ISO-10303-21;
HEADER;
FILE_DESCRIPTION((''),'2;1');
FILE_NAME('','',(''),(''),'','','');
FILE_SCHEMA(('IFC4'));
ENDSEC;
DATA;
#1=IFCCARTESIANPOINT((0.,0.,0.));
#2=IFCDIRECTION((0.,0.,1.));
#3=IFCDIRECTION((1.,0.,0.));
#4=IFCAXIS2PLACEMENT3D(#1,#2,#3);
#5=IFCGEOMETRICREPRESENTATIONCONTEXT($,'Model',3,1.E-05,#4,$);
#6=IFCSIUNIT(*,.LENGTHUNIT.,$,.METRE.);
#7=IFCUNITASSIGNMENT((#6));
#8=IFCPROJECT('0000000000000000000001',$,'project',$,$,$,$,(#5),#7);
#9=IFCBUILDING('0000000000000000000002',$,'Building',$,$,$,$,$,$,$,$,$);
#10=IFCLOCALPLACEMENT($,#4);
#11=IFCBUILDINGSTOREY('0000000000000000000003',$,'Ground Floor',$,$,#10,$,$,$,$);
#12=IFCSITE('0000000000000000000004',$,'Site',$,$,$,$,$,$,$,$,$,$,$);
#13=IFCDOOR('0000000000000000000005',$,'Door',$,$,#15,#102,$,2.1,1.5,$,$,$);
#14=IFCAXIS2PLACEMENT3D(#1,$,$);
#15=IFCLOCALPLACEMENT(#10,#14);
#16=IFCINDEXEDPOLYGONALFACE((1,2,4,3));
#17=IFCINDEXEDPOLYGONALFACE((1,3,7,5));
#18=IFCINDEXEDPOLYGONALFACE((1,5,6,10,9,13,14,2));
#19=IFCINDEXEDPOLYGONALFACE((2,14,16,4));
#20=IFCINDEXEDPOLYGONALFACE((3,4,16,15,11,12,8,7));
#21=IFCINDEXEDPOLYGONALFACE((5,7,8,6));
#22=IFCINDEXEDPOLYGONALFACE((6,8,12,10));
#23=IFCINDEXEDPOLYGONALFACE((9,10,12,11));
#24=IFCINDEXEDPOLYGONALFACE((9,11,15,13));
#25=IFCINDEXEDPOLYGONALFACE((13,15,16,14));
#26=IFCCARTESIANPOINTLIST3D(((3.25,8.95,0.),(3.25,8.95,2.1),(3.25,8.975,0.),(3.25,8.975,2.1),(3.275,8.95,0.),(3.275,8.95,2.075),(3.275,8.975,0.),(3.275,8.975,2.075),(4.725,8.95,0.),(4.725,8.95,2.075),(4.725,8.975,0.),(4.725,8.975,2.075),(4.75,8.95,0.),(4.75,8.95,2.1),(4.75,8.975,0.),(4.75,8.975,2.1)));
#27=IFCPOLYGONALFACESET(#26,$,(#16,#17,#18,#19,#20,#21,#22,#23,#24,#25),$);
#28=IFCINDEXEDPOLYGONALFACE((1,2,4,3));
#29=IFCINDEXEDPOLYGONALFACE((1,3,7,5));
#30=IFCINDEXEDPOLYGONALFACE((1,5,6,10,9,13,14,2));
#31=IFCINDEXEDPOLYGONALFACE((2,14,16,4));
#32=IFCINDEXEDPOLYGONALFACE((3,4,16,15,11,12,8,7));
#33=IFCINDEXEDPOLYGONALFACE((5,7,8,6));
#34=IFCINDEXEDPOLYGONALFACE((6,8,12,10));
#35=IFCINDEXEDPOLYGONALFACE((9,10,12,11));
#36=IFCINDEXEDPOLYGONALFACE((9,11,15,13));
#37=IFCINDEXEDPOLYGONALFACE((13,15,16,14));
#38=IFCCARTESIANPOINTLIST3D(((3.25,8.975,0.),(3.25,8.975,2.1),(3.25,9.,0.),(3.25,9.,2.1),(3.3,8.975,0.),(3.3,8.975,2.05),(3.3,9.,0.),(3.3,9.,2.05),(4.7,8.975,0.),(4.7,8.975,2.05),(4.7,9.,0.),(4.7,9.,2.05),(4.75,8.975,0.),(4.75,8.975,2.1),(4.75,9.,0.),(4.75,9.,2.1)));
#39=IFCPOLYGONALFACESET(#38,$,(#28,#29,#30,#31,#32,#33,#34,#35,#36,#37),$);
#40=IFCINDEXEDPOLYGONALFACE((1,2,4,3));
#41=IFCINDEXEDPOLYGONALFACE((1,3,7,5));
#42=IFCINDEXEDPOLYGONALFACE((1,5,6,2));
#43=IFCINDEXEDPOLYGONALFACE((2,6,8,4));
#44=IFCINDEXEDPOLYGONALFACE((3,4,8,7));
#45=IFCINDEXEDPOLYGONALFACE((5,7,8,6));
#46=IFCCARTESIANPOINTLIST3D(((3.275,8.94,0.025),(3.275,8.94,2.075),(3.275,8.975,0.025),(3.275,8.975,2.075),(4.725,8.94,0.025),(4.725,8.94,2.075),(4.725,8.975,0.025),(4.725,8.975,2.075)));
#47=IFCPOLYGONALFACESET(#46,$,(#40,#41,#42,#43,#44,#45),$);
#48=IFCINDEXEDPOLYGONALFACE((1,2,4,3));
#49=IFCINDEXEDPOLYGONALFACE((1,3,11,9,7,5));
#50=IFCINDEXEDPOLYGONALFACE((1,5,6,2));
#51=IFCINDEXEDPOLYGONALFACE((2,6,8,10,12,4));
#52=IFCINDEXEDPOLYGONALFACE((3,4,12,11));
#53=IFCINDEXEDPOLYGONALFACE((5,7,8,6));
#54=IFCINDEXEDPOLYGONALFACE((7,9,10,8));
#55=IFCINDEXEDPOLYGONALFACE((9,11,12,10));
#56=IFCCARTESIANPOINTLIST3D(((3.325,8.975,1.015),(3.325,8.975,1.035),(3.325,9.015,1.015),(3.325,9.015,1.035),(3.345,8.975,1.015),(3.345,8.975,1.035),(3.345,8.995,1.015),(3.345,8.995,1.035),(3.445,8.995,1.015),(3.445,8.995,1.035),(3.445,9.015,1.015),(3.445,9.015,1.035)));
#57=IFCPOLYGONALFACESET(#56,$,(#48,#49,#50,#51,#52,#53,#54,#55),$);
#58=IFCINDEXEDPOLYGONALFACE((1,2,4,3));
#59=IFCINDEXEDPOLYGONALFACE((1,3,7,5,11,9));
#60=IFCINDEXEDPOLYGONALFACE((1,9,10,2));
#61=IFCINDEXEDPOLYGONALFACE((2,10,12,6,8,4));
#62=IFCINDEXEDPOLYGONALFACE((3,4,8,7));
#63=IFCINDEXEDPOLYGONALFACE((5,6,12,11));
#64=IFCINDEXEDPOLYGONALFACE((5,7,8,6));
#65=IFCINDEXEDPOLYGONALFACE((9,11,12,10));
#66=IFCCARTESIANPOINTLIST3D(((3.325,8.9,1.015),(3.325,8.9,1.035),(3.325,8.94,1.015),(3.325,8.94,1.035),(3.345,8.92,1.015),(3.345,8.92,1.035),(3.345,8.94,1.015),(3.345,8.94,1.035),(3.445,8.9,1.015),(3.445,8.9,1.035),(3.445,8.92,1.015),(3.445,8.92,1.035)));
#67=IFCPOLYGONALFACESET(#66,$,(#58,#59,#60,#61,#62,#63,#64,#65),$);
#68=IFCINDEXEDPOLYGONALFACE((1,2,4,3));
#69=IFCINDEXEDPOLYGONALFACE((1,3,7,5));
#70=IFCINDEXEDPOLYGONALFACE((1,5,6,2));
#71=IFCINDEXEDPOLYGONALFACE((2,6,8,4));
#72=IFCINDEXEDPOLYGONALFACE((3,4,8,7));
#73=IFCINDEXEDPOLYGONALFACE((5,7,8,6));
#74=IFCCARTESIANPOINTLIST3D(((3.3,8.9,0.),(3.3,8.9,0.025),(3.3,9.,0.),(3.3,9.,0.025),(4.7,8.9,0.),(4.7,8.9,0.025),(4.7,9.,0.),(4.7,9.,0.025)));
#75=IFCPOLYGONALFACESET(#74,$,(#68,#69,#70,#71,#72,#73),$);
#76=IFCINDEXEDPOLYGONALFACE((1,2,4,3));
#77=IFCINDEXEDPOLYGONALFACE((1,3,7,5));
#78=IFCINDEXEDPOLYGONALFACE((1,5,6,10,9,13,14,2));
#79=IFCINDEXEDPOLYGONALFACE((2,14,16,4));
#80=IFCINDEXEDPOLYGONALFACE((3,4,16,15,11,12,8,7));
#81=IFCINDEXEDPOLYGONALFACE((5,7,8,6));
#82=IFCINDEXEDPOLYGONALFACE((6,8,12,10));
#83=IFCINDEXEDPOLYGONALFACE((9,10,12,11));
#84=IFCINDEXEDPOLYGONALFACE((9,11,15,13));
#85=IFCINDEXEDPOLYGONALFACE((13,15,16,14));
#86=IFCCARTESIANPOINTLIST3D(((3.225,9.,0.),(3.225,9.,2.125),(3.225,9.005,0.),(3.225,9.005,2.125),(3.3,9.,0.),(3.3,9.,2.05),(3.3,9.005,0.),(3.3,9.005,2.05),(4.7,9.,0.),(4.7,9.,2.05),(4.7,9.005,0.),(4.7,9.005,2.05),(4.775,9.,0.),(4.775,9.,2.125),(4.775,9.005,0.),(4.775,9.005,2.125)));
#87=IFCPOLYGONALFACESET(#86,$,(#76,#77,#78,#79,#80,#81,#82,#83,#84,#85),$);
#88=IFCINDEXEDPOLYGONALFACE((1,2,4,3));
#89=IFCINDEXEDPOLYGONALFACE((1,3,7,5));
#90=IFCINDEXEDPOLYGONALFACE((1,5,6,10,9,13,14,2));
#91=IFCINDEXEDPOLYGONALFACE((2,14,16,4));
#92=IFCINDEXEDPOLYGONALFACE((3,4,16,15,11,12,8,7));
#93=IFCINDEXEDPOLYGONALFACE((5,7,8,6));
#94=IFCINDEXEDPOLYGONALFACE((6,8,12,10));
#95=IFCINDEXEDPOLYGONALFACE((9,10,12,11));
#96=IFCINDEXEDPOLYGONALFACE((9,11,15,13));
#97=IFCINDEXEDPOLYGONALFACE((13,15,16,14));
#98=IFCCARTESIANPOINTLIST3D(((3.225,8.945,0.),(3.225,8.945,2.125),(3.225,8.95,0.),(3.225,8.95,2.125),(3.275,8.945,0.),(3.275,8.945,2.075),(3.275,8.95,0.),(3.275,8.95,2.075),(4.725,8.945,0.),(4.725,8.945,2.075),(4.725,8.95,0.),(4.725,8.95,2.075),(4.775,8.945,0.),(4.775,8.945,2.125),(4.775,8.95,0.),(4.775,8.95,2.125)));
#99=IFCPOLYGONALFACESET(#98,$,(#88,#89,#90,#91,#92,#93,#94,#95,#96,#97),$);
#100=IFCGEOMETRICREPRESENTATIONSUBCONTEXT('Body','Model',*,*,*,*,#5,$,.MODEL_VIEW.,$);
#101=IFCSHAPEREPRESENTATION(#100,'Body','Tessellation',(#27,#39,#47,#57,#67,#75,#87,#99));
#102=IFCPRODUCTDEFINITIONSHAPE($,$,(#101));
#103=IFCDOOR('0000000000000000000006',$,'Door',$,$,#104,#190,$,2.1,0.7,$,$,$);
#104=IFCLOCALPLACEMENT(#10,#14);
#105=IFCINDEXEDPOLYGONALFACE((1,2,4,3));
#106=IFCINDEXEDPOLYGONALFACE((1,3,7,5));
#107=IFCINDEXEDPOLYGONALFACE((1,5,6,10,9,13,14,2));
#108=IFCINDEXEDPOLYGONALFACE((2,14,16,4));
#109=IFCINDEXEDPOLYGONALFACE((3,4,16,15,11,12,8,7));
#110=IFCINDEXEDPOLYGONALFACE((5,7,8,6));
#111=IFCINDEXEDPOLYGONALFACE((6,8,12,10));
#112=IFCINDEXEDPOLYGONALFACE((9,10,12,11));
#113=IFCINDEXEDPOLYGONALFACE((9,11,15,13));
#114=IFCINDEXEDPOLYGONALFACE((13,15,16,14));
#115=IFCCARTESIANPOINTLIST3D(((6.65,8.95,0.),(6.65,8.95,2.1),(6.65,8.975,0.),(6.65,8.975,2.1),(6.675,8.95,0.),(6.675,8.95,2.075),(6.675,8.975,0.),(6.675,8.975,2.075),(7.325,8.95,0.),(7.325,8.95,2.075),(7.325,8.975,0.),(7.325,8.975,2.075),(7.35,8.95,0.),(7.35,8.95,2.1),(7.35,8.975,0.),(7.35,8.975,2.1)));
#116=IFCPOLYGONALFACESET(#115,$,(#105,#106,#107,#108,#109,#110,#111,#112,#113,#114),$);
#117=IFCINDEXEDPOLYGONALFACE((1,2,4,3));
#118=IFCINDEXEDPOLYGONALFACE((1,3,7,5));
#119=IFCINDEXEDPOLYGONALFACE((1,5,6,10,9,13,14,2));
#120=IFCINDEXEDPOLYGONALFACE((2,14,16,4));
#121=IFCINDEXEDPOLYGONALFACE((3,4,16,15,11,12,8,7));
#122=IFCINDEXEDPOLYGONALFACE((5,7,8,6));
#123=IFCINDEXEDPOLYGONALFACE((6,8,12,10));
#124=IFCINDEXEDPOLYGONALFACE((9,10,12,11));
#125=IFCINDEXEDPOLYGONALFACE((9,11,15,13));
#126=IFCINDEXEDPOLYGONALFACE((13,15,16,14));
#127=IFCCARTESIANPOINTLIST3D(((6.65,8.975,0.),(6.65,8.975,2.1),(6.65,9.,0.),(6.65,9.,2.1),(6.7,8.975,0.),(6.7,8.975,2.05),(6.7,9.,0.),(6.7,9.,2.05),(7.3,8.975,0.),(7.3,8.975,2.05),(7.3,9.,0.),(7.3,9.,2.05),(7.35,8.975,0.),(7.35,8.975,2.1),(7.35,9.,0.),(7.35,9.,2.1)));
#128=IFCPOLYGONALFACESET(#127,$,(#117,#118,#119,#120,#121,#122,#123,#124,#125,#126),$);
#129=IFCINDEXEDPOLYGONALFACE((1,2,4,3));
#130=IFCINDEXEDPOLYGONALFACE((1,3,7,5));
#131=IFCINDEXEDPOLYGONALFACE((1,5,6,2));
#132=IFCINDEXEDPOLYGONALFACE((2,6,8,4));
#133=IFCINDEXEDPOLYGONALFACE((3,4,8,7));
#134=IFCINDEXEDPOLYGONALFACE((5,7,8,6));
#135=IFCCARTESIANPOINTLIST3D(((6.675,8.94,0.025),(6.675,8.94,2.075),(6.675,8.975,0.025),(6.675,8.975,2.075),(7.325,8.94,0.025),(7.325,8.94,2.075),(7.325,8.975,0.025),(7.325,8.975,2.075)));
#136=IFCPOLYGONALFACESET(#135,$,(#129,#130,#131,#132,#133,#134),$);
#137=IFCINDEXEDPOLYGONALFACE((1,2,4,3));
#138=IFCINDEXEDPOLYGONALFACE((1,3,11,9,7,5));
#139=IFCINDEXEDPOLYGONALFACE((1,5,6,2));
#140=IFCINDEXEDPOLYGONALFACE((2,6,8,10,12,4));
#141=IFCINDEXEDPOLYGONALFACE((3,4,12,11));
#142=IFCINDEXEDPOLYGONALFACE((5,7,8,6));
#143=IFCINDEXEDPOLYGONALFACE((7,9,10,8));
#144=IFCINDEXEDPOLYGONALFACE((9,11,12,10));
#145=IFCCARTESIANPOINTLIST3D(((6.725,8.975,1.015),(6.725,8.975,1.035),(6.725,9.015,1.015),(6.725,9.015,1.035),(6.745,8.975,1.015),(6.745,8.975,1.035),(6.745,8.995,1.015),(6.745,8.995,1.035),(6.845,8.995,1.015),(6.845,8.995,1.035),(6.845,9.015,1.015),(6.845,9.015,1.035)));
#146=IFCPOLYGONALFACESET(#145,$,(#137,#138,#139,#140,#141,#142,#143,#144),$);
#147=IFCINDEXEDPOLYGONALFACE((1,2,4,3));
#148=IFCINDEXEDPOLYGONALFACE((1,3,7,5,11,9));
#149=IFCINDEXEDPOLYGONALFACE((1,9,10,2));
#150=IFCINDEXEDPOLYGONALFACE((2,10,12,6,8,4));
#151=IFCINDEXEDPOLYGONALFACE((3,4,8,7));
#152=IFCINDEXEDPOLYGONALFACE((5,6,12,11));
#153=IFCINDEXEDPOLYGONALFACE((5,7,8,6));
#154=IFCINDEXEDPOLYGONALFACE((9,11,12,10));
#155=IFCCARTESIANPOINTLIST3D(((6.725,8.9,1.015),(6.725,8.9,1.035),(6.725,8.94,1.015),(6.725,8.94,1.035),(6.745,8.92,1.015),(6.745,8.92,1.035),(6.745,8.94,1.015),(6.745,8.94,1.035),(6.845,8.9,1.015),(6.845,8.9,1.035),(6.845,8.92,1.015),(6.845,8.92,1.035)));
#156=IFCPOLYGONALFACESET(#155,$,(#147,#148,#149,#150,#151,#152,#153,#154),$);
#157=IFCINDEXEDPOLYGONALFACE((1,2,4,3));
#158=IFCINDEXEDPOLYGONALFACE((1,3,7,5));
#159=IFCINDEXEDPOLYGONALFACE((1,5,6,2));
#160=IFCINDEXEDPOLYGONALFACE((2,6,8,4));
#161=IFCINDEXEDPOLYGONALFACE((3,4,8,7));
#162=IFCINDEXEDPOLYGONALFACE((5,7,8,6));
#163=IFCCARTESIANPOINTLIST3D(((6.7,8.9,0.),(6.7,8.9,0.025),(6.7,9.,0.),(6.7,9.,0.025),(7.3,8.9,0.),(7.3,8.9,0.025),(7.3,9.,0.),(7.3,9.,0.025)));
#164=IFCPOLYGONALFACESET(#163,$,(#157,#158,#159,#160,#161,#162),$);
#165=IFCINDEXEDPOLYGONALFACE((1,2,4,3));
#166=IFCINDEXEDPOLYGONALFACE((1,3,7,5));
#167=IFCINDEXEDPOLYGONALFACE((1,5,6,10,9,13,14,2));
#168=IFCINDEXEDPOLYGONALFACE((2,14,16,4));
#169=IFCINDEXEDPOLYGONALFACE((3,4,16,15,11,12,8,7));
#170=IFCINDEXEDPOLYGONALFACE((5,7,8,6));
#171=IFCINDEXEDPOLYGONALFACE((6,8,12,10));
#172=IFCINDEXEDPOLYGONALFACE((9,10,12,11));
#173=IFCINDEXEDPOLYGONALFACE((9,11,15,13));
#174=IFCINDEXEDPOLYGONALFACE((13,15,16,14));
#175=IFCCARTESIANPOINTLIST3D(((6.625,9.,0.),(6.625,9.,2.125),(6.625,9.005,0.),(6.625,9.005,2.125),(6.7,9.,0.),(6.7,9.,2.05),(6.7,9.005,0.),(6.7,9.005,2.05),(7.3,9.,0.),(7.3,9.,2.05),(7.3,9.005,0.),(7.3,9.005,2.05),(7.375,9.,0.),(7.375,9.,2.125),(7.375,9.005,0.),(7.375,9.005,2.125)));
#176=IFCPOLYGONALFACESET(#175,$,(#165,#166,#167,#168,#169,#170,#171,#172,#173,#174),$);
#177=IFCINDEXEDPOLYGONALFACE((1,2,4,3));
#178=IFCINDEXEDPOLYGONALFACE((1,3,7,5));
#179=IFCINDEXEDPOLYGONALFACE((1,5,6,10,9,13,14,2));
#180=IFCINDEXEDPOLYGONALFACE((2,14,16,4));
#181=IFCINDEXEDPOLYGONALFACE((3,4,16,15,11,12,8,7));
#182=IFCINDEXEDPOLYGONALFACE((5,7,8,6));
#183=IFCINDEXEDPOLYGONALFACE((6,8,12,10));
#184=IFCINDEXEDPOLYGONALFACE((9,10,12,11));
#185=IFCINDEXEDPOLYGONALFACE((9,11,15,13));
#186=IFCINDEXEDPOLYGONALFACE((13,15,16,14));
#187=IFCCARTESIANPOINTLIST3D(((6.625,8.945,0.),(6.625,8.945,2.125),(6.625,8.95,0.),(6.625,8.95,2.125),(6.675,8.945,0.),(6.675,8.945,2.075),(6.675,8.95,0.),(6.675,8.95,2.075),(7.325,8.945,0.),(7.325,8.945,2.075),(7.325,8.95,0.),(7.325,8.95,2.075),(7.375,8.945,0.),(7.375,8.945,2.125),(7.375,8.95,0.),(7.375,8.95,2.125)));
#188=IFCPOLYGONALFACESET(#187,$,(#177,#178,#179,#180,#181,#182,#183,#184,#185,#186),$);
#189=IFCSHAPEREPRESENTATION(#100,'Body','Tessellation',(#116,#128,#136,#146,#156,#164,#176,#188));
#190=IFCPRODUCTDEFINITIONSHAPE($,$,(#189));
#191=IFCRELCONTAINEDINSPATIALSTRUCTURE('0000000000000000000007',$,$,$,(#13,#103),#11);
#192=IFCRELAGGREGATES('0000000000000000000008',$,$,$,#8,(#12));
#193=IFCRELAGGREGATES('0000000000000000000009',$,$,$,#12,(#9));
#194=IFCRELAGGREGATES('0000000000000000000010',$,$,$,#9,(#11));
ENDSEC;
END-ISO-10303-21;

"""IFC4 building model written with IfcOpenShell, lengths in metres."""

from ifc_helpers import new_model, si_unit, frame, origin_with_axes, place, context, subcontext, project, spatial, line, indexed_curve, outline, extrude, element, save


model = new_model("IFC4")

# Units and contexts
model_context = context("Model", 3, precision=1e-05, world=origin_with_axes())
body_context = subcontext(model_context, "Body", "Model", "MODEL_VIEW")
ifc_project = project(units=[si_unit("LENGTHUNIT", "METRE")], contexts=[model_context])

# Site, building, storey
site = spatial("IfcSite", under=ifc_project, Name="Site")
building = spatial("IfcBuilding", under=site, Name="Building")
storey_placement = place(None, origin_with_axes())
storey = spatial("IfcBuildingStorey", under=building, at=storey_placement, Name="Ground Floor")

# Doors
door_1_placement = place(storey_placement, frame((4.75, 9.0, 0.0), z_axis=(0.0, 0.0, 1.0), x_axis=(-1.0, 0.0, 0.0)))
element("IfcDoor", 1, at=door_1_placement, inside=storey, Name="Door", OverallHeight=2.1, OverallWidth=1.5, context=body_context, shape_type="SweptSolid", body=[
    extrude(outline(indexed_curve([(0.0, 0.0), (0.0, 2.1), (1.5, 2.1), (1.5, 0.0), (1.475, 0.0), (1.475, 2.075), (0.025, 2.075), (0.025, 0.0)], segments=[line(1, 2, 3, 4, 5, 6, 7, 8, 1)])), frame((0.0, 0.025, 0.0), z_axis=(0.0, -1.0, 0.0), x_axis=(1.0, 0.0, 0.0)), (0.0, 0.0, -1.0), 0.025),
    extrude(outline(indexed_curve([(0.0, 0.0), (0.0, 2.1), (1.5, 2.1), (1.5, 0.0), (1.45, 0.0), (1.45, 2.05), (0.05, 2.05), (0.05, 0.0)], segments=[line(1, 2, 3, 4, 5, 6, 7, 8, 1)])), frame((0.0, 0.0, 0.0), z_axis=(0.0, -1.0, 0.0), x_axis=(1.0, 0.0, 0.0)), (0.0, 0.0, -1.0), 0.025),
    extrude(outline(indexed_curve([(0.0, 0.0), (1.45, 0.0), (1.45, 0.035), (0.0, 0.035)], segments=[line(1, 2, 3, 4, 1)])), frame((0.025, 0.025, 0.025), z_axis=(0.0, 0.0, 1.0), x_axis=(1.0, 0.0, 0.0)), (0.0, 0.0, 1.0), 2.05),
    extrude(outline(indexed_curve([(0.0, 0.0), (0.0, -0.04), (-0.12, -0.04), (-0.12, -0.02), (-0.02, -0.02), (-0.02, 0.0)], segments=[line(1, 2, 3, 4, 5, 6, 1)])), frame((1.425, 0.025, 1.015), z_axis=(0.0, 0.0, 1.0), x_axis=(1.0, 0.0, 0.0)), (0.0, 0.0, 1.0), 0.02),
    extrude(outline(indexed_curve([(0.0, 0.0), (0.0, 0.04), (-0.12, 0.04), (-0.12, 0.02), (-0.02, 0.02), (-0.02, 0.0)], segments=[line(1, 2, 3, 4, 5, 6, 1)])), frame((1.425, 0.06, 1.015), z_axis=(0.0, 0.0, 1.0), x_axis=(1.0, 0.0, 0.0)), (0.0, 0.0, 1.0), 0.02),
    extrude(outline(indexed_curve([(0.0, 0.0), (1.4, 0.0), (1.4, 0.1), (0.0, 0.1)], segments=[line(1, 2, 3, 4, 1)])), frame((0.05, 0.0, 0.0), z_axis=(0.0, 0.0, 1.0), x_axis=(1.0, 0.0, 0.0)), (0.0, 0.0, 1.0), 0.025),
    extrude(outline(indexed_curve([(0.0, 0.0), (0.0, 2.125), (1.55, 2.125), (1.55, 0.0), (1.475, 0.0), (1.475, 2.05), (0.075, 2.05), (0.075, 0.0)], segments=[line(1, 2, 3, 4, 5, 6, 7, 8, 1)])), frame((-0.025, -0.005, 0.0), z_axis=(0.0, -1.0, 0.0), x_axis=(1.0, 0.0, 0.0)), (0.0, 0.0, -1.0), 0.005),
    extrude(outline(indexed_curve([(0.0, 0.0), (0.0, 2.125), (1.55, 2.125), (1.55, 0.0), (1.5, 0.0), (1.5, 2.075), (0.05, 2.075), (0.05, 0.0)], segments=[line(1, 2, 3, 4, 5, 6, 7, 8, 1)])), frame((-0.025, 0.05, 0.0), z_axis=(0.0, -1.0, 0.0), x_axis=(1.0, 0.0, 0.0)), (0.0, 0.0, -1.0), 0.005),
])
door_2_placement = place(storey_placement, frame((7.35, 9.0, 0.0), z_axis=(0.0, 0.0, 1.0), x_axis=(-1.0, 0.0, 0.0)))
element("IfcDoor", 2, at=door_2_placement, inside=storey, Name="Door", OverallHeight=2.1, OverallWidth=0.7, context=body_context, shape_type="SweptSolid", body=[
    extrude(outline(indexed_curve([(0.0, 0.0), (0.0, 2.1), (0.7, 2.1), (0.7, 0.0), (0.675, 0.0), (0.675, 2.075), (0.025, 2.075), (0.025, 0.0)], segments=[line(1, 2, 3, 4, 5, 6, 7, 8, 1)])), frame((0.0, 0.025, 0.0), z_axis=(0.0, -1.0, 0.0), x_axis=(1.0, 0.0, 0.0)), (0.0, 0.0, -1.0), 0.025),
    extrude(outline(indexed_curve([(0.0, 0.0), (0.0, 2.1), (0.7, 2.1), (0.7, 0.0), (0.65, 0.0), (0.65, 2.05), (0.05, 2.05), (0.05, 0.0)], segments=[line(1, 2, 3, 4, 5, 6, 7, 8, 1)])), frame((0.0, 0.0, 0.0), z_axis=(0.0, -1.0, 0.0), x_axis=(1.0, 0.0, 0.0)), (0.0, 0.0, -1.0), 0.025),
    extrude(outline(indexed_curve([(0.0, 0.0), (0.65, 0.0), (0.65, 0.035), (0.0, 0.035)], segments=[line(1, 2, 3, 4, 1)])), frame((0.025, 0.025, 0.025), z_axis=(0.0, 0.0, 1.0), x_axis=(1.0, 0.0, 0.0)), (0.0, 0.0, 1.0), 2.05),
    extrude(outline(indexed_curve([(0.0, 0.0), (0.0, -0.04), (-0.12, -0.04), (-0.12, -0.02), (-0.02, -0.02), (-0.02, 0.0)], segments=[line(1, 2, 3, 4, 5, 6, 1)])), frame((0.625, 0.025, 1.015), z_axis=(0.0, 0.0, 1.0), x_axis=(1.0, 0.0, 0.0)), (0.0, 0.0, 1.0), 0.02),
    extrude(outline(indexed_curve([(0.0, 0.0), (0.0, 0.04), (-0.12, 0.04), (-0.12, 0.02), (-0.02, 0.02), (-0.02, 0.0)], segments=[line(1, 2, 3, 4, 5, 6, 1)])), frame((0.625, 0.06, 1.015), z_axis=(0.0, 0.0, 1.0), x_axis=(1.0, 0.0, 0.0)), (0.0, 0.0, 1.0), 0.02),
    extrude(outline(indexed_curve([(0.0, 0.0), (0.6, 0.0), (0.6, 0.1), (0.0, 0.1)], segments=[line(1, 2, 3, 4, 1)])), frame((0.05, 0.0, 0.0), z_axis=(0.0, 0.0, 1.0), x_axis=(1.0, 0.0, 0.0)), (0.0, 0.0, 1.0), 0.025),
    extrude(outline(indexed_curve([(0.0, 0.0), (0.0, 2.125), (0.75, 2.125), (0.75, 0.0), (0.675, 0.0), (0.675, 2.05), (0.075, 2.05), (0.075, 0.0)], segments=[line(1, 2, 3, 4, 5, 6, 7, 8, 1)])), frame((-0.025, -0.005, 0.0), z_axis=(0.0, -1.0, 0.0), x_axis=(1.0, 0.0, 0.0)), (0.0, 0.0, -1.0), 0.005),
    extrude(outline(indexed_curve([(0.0, 0.0), (0.0, 2.125), (0.75, 2.125), (0.75, 0.0), (0.7, 0.0), (0.7, 2.075), (0.05, 2.075), (0.05, 0.0)], segments=[line(1, 2, 3, 4, 5, 6, 7, 8, 1)])), frame((-0.025, 0.05, 0.0), z_axis=(0.0, -1.0, 0.0), x_axis=(1.0, 0.0, 0.0)), (0.0, 0.0, -1.0), 0.005),
])

save(model, "model.ifc")
